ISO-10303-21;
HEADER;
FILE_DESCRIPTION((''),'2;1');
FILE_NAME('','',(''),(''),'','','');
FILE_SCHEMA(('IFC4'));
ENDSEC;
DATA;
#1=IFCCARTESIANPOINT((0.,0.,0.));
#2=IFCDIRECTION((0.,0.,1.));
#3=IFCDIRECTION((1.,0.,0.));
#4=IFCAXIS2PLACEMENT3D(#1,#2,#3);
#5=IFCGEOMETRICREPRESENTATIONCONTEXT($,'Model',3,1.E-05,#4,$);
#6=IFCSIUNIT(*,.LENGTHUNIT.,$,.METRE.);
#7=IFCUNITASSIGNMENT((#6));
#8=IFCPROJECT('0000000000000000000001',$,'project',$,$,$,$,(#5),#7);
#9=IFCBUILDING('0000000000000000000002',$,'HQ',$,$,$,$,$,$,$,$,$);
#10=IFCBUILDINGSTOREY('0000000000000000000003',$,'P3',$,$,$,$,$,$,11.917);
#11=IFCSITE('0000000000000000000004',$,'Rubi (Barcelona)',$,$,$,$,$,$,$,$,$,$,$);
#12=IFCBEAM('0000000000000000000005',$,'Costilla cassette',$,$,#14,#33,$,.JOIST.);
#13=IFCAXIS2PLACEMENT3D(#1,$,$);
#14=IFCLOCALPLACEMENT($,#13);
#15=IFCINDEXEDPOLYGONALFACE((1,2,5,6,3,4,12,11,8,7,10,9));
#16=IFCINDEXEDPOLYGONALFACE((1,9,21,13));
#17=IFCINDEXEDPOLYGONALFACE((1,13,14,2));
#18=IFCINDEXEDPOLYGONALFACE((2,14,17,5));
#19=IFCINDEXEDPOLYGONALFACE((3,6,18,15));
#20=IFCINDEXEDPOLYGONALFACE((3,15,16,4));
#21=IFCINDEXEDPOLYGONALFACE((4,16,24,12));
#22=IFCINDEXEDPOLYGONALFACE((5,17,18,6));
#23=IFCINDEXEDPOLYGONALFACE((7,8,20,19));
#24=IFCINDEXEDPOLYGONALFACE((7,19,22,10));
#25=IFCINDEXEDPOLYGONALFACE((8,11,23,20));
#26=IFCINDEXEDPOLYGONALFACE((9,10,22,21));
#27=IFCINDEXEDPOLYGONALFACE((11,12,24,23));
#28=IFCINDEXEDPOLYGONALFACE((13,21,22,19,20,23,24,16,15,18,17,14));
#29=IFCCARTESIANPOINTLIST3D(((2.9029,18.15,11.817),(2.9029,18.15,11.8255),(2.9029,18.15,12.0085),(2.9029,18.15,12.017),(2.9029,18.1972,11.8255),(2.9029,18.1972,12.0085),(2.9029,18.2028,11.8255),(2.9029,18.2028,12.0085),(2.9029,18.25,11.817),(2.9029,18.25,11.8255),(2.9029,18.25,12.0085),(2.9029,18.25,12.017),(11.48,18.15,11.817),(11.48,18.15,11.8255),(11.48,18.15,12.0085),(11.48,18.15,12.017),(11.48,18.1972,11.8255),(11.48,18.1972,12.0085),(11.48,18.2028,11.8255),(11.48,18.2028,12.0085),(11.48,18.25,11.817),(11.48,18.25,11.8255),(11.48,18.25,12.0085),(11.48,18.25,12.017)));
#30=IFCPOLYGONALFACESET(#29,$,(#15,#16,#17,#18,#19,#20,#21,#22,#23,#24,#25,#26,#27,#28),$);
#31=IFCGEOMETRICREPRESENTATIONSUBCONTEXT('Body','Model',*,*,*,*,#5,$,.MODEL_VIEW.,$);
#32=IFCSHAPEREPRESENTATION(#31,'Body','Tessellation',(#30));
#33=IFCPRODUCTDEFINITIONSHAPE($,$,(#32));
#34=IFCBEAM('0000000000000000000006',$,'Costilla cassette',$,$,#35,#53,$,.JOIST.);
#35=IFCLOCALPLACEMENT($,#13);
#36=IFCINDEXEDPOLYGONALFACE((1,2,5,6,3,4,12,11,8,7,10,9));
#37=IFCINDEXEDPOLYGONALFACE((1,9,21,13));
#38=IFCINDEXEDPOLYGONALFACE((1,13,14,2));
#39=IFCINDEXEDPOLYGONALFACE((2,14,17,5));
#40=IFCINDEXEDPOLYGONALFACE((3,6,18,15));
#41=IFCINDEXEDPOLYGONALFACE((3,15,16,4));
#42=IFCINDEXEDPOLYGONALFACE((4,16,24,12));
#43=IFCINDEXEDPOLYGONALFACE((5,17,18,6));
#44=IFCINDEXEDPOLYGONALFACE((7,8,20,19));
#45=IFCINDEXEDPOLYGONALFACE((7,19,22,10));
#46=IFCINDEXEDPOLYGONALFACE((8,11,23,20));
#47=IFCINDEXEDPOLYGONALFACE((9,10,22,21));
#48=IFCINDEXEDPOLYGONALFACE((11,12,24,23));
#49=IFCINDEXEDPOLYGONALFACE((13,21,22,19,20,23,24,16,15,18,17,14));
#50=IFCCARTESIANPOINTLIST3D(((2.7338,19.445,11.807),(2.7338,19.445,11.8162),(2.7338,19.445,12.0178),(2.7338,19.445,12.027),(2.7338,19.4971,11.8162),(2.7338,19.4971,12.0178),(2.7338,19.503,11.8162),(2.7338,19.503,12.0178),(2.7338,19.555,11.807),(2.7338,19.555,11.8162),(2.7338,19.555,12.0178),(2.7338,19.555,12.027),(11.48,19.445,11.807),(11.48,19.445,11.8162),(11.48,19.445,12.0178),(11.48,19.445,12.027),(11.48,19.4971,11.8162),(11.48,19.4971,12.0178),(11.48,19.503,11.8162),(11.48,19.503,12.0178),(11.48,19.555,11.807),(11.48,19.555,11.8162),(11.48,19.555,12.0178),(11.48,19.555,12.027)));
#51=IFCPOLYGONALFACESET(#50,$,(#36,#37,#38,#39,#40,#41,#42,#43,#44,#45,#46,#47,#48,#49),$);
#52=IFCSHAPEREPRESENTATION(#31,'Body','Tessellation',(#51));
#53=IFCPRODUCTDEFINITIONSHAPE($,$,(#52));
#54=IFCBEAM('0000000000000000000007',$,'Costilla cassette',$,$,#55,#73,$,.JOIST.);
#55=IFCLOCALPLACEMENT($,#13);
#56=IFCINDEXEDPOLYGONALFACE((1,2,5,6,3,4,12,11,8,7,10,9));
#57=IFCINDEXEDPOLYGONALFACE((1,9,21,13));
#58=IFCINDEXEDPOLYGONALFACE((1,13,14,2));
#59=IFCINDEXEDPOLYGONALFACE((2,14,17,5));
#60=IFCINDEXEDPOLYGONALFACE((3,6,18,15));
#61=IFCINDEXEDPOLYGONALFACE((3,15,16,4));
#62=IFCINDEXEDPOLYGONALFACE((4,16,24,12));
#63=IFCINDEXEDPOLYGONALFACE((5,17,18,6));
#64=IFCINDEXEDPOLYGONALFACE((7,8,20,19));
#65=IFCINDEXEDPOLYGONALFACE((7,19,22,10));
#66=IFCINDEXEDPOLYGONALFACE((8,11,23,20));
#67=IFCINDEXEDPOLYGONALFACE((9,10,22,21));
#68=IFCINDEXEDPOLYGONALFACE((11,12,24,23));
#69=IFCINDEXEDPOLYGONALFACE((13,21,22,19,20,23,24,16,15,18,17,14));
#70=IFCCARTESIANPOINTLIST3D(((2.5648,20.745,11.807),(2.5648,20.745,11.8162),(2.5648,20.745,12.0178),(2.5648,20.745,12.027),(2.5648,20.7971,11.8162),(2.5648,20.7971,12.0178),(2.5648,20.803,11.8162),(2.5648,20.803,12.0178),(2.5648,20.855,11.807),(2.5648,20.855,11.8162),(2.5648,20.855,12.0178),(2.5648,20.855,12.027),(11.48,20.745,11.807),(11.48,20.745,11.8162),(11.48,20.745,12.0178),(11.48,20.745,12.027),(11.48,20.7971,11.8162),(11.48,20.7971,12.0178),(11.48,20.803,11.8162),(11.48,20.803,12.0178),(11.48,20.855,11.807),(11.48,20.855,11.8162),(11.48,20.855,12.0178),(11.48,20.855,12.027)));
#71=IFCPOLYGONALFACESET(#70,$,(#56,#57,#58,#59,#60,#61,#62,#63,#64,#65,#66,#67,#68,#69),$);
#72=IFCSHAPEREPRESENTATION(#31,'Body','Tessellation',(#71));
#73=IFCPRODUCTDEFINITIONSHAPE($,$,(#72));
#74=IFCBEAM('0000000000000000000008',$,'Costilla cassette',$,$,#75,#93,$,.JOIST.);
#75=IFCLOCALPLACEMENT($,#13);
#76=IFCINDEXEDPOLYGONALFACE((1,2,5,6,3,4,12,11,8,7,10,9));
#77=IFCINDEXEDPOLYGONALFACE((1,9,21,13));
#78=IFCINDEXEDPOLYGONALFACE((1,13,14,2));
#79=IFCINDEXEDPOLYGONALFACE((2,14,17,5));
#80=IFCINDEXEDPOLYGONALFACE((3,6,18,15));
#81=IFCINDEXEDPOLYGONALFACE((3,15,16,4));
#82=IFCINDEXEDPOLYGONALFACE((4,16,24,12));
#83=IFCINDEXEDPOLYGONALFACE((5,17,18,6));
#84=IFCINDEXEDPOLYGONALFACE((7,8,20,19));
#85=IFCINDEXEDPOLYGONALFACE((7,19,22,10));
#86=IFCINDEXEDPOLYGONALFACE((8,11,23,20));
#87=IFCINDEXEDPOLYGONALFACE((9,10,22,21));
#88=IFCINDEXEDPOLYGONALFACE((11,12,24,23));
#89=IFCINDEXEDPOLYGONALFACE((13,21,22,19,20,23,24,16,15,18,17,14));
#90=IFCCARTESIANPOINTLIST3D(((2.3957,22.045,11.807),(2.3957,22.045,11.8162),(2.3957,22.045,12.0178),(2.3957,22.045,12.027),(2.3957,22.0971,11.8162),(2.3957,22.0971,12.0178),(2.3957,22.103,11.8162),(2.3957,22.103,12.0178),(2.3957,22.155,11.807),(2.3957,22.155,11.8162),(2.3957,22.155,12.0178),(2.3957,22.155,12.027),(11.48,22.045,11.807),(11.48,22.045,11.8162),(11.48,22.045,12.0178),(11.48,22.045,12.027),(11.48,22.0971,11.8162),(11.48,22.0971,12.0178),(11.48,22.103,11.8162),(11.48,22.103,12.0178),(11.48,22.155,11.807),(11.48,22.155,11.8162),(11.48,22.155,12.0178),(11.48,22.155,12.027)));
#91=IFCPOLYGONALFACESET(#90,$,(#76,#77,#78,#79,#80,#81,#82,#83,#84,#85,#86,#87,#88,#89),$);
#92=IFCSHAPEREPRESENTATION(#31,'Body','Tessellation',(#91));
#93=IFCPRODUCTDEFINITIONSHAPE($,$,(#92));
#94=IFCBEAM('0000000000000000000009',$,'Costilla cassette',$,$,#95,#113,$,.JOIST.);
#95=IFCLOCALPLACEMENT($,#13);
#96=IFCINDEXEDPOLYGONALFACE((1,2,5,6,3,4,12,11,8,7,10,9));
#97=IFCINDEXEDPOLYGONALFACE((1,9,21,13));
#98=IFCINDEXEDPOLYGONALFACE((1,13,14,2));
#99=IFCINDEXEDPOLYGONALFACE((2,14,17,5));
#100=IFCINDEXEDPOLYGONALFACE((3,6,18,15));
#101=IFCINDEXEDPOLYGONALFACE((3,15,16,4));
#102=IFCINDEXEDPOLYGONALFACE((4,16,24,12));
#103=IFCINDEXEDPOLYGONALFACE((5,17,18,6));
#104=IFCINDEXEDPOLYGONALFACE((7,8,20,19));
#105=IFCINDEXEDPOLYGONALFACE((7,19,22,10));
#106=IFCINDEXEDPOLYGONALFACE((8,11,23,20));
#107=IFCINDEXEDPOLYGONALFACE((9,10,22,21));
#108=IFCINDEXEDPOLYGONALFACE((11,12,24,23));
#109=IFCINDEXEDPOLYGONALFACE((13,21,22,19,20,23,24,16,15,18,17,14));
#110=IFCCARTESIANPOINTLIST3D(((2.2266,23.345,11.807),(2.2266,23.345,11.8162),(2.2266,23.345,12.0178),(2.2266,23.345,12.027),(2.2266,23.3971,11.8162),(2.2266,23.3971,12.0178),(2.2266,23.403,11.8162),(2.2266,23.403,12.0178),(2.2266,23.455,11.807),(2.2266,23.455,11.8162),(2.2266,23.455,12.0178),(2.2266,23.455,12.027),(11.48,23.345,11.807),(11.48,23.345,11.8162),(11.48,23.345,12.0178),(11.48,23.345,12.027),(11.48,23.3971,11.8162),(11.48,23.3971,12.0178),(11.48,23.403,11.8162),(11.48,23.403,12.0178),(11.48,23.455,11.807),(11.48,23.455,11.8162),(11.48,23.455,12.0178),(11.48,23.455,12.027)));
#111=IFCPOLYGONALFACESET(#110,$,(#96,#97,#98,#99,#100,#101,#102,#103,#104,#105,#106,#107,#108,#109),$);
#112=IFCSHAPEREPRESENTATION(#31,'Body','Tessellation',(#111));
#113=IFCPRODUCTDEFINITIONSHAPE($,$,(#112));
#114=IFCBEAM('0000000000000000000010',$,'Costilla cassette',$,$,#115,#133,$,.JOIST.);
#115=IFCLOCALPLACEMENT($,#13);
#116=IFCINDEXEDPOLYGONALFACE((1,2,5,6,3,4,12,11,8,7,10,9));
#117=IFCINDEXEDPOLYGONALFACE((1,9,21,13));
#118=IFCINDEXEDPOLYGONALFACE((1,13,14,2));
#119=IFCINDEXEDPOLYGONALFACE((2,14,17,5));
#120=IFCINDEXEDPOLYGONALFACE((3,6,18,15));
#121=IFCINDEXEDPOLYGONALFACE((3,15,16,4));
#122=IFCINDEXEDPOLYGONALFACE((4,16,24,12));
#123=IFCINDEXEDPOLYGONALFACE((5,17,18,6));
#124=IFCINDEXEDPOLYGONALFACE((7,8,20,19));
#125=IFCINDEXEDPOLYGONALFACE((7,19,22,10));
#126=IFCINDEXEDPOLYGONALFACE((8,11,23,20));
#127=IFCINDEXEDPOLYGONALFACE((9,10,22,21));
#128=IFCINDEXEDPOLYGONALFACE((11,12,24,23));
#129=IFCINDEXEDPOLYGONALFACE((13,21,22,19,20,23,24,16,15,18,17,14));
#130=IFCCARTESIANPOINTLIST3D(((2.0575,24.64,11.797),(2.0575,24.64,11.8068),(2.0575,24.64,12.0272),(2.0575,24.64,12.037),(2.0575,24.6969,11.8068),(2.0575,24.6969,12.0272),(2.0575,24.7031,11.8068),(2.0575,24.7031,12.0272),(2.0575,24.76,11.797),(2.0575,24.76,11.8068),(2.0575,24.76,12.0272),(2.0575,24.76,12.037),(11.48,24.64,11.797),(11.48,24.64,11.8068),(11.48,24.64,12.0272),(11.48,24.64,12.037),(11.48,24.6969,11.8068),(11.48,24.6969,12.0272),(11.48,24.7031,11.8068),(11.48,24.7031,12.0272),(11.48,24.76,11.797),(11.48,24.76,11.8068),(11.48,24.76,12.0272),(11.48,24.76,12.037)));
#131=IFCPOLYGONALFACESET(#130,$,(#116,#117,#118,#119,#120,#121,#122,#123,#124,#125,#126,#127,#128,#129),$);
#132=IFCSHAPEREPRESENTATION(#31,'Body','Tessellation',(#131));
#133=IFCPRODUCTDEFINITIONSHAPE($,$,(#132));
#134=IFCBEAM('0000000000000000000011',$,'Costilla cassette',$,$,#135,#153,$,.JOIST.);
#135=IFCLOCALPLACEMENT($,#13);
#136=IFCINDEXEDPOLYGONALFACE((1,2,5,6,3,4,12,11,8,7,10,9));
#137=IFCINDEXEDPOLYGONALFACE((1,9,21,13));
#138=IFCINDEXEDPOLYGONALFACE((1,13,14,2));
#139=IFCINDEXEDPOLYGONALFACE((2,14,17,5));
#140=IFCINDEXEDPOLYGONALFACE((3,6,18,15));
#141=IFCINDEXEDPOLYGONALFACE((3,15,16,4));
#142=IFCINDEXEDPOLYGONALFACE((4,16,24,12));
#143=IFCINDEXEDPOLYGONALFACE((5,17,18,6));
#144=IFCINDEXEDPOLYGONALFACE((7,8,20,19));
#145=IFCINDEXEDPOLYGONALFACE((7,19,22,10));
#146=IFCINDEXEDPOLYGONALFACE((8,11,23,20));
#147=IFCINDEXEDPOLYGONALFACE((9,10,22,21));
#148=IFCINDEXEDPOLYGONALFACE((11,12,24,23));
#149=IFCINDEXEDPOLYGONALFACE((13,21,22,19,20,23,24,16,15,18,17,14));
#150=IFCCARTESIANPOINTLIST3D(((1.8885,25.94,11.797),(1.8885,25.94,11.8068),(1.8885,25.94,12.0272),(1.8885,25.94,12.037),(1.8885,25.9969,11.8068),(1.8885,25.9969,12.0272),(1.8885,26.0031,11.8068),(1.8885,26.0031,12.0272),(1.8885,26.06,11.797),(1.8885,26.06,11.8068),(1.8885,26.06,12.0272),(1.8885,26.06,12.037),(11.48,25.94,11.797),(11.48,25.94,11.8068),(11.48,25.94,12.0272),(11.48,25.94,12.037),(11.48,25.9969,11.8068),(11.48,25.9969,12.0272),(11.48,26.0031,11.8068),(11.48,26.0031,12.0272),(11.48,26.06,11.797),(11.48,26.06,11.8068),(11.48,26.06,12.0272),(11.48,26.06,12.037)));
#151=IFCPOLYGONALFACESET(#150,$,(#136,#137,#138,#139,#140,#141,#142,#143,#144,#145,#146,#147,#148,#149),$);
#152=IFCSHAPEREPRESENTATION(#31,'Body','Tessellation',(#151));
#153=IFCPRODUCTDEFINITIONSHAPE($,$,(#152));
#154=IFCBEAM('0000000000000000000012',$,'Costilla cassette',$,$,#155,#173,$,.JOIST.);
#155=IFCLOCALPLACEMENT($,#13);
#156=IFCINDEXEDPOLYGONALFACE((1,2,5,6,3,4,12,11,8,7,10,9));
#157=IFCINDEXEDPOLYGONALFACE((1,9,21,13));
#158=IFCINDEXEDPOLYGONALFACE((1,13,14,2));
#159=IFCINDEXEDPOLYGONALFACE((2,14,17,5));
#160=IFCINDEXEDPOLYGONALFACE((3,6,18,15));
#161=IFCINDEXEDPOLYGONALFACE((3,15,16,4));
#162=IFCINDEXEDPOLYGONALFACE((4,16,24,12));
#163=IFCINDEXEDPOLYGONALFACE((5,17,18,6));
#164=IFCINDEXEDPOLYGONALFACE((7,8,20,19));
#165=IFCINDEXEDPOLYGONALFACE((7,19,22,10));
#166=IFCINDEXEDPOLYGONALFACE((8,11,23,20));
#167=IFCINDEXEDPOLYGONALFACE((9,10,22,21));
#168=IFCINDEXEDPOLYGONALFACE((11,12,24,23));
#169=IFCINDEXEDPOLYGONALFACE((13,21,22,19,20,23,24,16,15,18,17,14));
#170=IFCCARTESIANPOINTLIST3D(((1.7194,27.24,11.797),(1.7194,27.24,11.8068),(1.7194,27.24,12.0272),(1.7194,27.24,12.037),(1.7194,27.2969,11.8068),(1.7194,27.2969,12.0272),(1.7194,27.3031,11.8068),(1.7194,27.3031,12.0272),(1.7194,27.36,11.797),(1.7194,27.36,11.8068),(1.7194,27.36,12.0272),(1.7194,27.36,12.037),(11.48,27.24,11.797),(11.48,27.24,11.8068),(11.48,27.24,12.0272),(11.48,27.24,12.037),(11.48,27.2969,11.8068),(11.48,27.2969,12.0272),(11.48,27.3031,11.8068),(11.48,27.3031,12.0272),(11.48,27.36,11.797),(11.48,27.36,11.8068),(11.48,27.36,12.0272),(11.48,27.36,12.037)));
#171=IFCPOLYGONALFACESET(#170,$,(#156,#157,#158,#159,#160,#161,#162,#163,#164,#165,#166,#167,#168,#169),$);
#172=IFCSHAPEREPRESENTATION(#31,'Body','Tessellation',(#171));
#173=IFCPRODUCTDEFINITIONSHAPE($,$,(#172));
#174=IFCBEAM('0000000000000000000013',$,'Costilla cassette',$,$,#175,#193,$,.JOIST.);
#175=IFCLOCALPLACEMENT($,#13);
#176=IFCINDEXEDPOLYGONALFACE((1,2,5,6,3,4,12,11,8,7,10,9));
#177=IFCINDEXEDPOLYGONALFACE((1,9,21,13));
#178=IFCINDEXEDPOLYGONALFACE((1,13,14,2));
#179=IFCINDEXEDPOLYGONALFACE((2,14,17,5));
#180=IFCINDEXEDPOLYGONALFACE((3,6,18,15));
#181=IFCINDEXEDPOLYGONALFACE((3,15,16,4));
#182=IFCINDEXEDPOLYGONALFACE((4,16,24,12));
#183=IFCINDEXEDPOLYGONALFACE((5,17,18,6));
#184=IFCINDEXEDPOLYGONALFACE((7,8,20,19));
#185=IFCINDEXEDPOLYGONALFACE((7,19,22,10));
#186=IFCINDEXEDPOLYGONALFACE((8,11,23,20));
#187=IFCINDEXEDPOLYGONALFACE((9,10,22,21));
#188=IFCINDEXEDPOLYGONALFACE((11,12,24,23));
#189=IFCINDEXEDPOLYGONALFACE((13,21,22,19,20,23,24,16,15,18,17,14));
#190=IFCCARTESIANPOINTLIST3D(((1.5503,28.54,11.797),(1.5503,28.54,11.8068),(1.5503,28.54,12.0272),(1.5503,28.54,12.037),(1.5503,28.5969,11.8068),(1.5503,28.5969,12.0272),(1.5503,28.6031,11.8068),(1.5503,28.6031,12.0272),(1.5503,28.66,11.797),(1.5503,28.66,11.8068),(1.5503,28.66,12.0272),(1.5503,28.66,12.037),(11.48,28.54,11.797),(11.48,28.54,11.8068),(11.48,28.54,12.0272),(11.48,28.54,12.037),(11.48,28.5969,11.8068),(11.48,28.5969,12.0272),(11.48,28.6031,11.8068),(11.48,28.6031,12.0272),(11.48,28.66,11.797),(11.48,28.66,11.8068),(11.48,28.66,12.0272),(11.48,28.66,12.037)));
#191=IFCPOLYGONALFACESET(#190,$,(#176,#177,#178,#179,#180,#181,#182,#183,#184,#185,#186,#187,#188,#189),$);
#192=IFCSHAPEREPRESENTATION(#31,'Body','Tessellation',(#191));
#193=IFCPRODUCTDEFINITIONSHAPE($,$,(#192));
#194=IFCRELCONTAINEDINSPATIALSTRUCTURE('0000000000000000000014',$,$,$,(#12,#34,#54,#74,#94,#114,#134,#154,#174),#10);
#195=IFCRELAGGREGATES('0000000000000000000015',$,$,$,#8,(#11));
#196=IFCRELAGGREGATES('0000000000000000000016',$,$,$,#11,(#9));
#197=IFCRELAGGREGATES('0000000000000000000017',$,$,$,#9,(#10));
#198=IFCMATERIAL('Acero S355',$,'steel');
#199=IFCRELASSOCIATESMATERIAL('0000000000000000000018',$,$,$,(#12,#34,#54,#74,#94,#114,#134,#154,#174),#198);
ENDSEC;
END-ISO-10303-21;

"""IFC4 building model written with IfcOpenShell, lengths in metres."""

from ifc_helpers import new_model, si_unit, frame, origin_with_axes, place, context, subcontext, project, spatial, i_section, extrude, material, element, save


model = new_model("IFC4")

# Units and contexts
model_context = context("Model", 3, precision=1e-05, world=origin_with_axes())
body_context = subcontext(model_context, "Body", "Model", "MODEL_VIEW")
ifc_project = project(units=[si_unit("LENGTHUNIT", "METRE")], contexts=[model_context])

# Site, building, storey
site = spatial("IfcSite", under=ifc_project, Name="Rubi (Barcelona)")
building = spatial("IfcBuilding", under=site, Name="HQ")
storey = spatial("IfcBuildingStorey", under=building, Name="P3", Elevation=11.917)

# Beams
ifc_material_1 = material(Name="Acero S355", Category="steel")
beam_1_placement = place(None, origin_with_axes())
element("IfcBeam", 1, at=beam_1_placement, inside=storey, material=ifc_material_1, Name="Costilla cassette", PredefinedType="JOIST", context=body_context, shape_type="SweptSolid", body=[
    extrude(i_section(OverallWidth=0.1, OverallDepth=0.2, WebThickness=0.0056, FlangeThickness=0.0085), frame((2.9029, 18.2, 11.917), z_axis=(1.0, 0.0, 0.0), x_axis=(0.0, 1.0, 0.0)), (0.0, 0.0, 1.0), 8.5771),
])
beam_2_placement = place(None, origin_with_axes())
element("IfcBeam", 2, at=beam_2_placement, inside=storey, material=ifc_material_1, Name="Costilla cassette", PredefinedType="JOIST", context=body_context, shape_type="SweptSolid", body=[
    extrude(i_section(OverallWidth=0.11, OverallDepth=0.22, WebThickness=0.0059, FlangeThickness=0.0092), frame((2.7338, 19.5, 11.917), z_axis=(1.0, 0.0, 0.0), x_axis=(0.0, 1.0, 0.0)), (0.0, 0.0, 1.0), 8.7462),
])
beam_3_placement = place(None, origin_with_axes())
element("IfcBeam", 3, at=beam_3_placement, inside=storey, material=ifc_material_1, Name="Costilla cassette", PredefinedType="JOIST", context=body_context, shape_type="SweptSolid", body=[
    extrude(i_section(OverallWidth=0.11, OverallDepth=0.22, WebThickness=0.0059, FlangeThickness=0.0092), frame((2.5648, 20.8, 11.917), z_axis=(1.0, 0.0, 0.0), x_axis=(0.0, 1.0, 0.0)), (0.0, 0.0, 1.0), 8.9152),
])
beam_4_placement = place(None, origin_with_axes())
element("IfcBeam", 4, at=beam_4_placement, inside=storey, material=ifc_material_1, Name="Costilla cassette", PredefinedType="JOIST", context=body_context, shape_type="SweptSolid", body=[
    extrude(i_section(OverallWidth=0.11, OverallDepth=0.22, WebThickness=0.0059, FlangeThickness=0.0092), frame((2.3957, 22.1, 11.917), z_axis=(1.0, 0.0, 0.0), x_axis=(0.0, 1.0, 0.0)), (0.0, 0.0, 1.0), 9.0843),
])
beam_5_placement = place(None, origin_with_axes())
element("IfcBeam", 5, at=beam_5_placement, inside=storey, material=ifc_material_1, Name="Costilla cassette", PredefinedType="JOIST", context=body_context, shape_type="SweptSolid", body=[
    extrude(i_section(OverallWidth=0.11, OverallDepth=0.22, WebThickness=0.0059, FlangeThickness=0.0092), frame((2.2266, 23.4, 11.917), z_axis=(1.0, 0.0, 0.0), x_axis=(0.0, 1.0, 0.0)), (0.0, 0.0, 1.0), 9.2534),
])
beam_6_placement = place(None, origin_with_axes())
element("IfcBeam", 6, at=beam_6_placement, inside=storey, material=ifc_material_1, Name="Costilla cassette", PredefinedType="JOIST", context=body_context, shape_type="SweptSolid", body=[
    extrude(i_section(OverallWidth=0.12, OverallDepth=0.24, WebThickness=0.0062, FlangeThickness=0.0098), frame((2.0575, 24.7, 11.917), z_axis=(1.0, 0.0, 0.0), x_axis=(0.0, 1.0, 0.0)), (0.0, 0.0, 1.0), 9.4225),
])
beam_7_placement = place(None, origin_with_axes())
element("IfcBeam", 7, at=beam_7_placement, inside=storey, material=ifc_material_1, Name="Costilla cassette", PredefinedType="JOIST", context=body_context, shape_type="SweptSolid", body=[
    extrude(i_section(OverallWidth=0.12, OverallDepth=0.24, WebThickness=0.0062, FlangeThickness=0.0098), frame((1.8885, 26.0, 11.917), z_axis=(1.0, 0.0, 0.0), x_axis=(0.0, 1.0, 0.0)), (0.0, 0.0, 1.0), 9.5915),
])
beam_8_placement = place(None, origin_with_axes())
element("IfcBeam", 8, at=beam_8_placement, inside=storey, material=ifc_material_1, Name="Costilla cassette", PredefinedType="JOIST", context=body_context, shape_type="SweptSolid", body=[
    extrude(i_section(OverallWidth=0.12, OverallDepth=0.24, WebThickness=0.0062, FlangeThickness=0.0098), frame((1.7194, 27.3, 11.917), z_axis=(1.0, 0.0, 0.0), x_axis=(0.0, 1.0, 0.0)), (0.0, 0.0, 1.0), 9.7606),
])
beam_9_placement = place(None, origin_with_axes())
element("IfcBeam", 9, at=beam_9_placement, inside=storey, material=ifc_material_1, Name="Costilla cassette", PredefinedType="JOIST", context=body_context, shape_type="SweptSolid", body=[
    extrude(i_section(OverallWidth=0.12, OverallDepth=0.24, WebThickness=0.0062, FlangeThickness=0.0098), frame((1.5503, 28.6, 11.917), z_axis=(1.0, 0.0, 0.0), x_axis=(0.0, 1.0, 0.0)), (0.0, 0.0, 1.0), 9.9297),
])

save(model, "model.ifc")
